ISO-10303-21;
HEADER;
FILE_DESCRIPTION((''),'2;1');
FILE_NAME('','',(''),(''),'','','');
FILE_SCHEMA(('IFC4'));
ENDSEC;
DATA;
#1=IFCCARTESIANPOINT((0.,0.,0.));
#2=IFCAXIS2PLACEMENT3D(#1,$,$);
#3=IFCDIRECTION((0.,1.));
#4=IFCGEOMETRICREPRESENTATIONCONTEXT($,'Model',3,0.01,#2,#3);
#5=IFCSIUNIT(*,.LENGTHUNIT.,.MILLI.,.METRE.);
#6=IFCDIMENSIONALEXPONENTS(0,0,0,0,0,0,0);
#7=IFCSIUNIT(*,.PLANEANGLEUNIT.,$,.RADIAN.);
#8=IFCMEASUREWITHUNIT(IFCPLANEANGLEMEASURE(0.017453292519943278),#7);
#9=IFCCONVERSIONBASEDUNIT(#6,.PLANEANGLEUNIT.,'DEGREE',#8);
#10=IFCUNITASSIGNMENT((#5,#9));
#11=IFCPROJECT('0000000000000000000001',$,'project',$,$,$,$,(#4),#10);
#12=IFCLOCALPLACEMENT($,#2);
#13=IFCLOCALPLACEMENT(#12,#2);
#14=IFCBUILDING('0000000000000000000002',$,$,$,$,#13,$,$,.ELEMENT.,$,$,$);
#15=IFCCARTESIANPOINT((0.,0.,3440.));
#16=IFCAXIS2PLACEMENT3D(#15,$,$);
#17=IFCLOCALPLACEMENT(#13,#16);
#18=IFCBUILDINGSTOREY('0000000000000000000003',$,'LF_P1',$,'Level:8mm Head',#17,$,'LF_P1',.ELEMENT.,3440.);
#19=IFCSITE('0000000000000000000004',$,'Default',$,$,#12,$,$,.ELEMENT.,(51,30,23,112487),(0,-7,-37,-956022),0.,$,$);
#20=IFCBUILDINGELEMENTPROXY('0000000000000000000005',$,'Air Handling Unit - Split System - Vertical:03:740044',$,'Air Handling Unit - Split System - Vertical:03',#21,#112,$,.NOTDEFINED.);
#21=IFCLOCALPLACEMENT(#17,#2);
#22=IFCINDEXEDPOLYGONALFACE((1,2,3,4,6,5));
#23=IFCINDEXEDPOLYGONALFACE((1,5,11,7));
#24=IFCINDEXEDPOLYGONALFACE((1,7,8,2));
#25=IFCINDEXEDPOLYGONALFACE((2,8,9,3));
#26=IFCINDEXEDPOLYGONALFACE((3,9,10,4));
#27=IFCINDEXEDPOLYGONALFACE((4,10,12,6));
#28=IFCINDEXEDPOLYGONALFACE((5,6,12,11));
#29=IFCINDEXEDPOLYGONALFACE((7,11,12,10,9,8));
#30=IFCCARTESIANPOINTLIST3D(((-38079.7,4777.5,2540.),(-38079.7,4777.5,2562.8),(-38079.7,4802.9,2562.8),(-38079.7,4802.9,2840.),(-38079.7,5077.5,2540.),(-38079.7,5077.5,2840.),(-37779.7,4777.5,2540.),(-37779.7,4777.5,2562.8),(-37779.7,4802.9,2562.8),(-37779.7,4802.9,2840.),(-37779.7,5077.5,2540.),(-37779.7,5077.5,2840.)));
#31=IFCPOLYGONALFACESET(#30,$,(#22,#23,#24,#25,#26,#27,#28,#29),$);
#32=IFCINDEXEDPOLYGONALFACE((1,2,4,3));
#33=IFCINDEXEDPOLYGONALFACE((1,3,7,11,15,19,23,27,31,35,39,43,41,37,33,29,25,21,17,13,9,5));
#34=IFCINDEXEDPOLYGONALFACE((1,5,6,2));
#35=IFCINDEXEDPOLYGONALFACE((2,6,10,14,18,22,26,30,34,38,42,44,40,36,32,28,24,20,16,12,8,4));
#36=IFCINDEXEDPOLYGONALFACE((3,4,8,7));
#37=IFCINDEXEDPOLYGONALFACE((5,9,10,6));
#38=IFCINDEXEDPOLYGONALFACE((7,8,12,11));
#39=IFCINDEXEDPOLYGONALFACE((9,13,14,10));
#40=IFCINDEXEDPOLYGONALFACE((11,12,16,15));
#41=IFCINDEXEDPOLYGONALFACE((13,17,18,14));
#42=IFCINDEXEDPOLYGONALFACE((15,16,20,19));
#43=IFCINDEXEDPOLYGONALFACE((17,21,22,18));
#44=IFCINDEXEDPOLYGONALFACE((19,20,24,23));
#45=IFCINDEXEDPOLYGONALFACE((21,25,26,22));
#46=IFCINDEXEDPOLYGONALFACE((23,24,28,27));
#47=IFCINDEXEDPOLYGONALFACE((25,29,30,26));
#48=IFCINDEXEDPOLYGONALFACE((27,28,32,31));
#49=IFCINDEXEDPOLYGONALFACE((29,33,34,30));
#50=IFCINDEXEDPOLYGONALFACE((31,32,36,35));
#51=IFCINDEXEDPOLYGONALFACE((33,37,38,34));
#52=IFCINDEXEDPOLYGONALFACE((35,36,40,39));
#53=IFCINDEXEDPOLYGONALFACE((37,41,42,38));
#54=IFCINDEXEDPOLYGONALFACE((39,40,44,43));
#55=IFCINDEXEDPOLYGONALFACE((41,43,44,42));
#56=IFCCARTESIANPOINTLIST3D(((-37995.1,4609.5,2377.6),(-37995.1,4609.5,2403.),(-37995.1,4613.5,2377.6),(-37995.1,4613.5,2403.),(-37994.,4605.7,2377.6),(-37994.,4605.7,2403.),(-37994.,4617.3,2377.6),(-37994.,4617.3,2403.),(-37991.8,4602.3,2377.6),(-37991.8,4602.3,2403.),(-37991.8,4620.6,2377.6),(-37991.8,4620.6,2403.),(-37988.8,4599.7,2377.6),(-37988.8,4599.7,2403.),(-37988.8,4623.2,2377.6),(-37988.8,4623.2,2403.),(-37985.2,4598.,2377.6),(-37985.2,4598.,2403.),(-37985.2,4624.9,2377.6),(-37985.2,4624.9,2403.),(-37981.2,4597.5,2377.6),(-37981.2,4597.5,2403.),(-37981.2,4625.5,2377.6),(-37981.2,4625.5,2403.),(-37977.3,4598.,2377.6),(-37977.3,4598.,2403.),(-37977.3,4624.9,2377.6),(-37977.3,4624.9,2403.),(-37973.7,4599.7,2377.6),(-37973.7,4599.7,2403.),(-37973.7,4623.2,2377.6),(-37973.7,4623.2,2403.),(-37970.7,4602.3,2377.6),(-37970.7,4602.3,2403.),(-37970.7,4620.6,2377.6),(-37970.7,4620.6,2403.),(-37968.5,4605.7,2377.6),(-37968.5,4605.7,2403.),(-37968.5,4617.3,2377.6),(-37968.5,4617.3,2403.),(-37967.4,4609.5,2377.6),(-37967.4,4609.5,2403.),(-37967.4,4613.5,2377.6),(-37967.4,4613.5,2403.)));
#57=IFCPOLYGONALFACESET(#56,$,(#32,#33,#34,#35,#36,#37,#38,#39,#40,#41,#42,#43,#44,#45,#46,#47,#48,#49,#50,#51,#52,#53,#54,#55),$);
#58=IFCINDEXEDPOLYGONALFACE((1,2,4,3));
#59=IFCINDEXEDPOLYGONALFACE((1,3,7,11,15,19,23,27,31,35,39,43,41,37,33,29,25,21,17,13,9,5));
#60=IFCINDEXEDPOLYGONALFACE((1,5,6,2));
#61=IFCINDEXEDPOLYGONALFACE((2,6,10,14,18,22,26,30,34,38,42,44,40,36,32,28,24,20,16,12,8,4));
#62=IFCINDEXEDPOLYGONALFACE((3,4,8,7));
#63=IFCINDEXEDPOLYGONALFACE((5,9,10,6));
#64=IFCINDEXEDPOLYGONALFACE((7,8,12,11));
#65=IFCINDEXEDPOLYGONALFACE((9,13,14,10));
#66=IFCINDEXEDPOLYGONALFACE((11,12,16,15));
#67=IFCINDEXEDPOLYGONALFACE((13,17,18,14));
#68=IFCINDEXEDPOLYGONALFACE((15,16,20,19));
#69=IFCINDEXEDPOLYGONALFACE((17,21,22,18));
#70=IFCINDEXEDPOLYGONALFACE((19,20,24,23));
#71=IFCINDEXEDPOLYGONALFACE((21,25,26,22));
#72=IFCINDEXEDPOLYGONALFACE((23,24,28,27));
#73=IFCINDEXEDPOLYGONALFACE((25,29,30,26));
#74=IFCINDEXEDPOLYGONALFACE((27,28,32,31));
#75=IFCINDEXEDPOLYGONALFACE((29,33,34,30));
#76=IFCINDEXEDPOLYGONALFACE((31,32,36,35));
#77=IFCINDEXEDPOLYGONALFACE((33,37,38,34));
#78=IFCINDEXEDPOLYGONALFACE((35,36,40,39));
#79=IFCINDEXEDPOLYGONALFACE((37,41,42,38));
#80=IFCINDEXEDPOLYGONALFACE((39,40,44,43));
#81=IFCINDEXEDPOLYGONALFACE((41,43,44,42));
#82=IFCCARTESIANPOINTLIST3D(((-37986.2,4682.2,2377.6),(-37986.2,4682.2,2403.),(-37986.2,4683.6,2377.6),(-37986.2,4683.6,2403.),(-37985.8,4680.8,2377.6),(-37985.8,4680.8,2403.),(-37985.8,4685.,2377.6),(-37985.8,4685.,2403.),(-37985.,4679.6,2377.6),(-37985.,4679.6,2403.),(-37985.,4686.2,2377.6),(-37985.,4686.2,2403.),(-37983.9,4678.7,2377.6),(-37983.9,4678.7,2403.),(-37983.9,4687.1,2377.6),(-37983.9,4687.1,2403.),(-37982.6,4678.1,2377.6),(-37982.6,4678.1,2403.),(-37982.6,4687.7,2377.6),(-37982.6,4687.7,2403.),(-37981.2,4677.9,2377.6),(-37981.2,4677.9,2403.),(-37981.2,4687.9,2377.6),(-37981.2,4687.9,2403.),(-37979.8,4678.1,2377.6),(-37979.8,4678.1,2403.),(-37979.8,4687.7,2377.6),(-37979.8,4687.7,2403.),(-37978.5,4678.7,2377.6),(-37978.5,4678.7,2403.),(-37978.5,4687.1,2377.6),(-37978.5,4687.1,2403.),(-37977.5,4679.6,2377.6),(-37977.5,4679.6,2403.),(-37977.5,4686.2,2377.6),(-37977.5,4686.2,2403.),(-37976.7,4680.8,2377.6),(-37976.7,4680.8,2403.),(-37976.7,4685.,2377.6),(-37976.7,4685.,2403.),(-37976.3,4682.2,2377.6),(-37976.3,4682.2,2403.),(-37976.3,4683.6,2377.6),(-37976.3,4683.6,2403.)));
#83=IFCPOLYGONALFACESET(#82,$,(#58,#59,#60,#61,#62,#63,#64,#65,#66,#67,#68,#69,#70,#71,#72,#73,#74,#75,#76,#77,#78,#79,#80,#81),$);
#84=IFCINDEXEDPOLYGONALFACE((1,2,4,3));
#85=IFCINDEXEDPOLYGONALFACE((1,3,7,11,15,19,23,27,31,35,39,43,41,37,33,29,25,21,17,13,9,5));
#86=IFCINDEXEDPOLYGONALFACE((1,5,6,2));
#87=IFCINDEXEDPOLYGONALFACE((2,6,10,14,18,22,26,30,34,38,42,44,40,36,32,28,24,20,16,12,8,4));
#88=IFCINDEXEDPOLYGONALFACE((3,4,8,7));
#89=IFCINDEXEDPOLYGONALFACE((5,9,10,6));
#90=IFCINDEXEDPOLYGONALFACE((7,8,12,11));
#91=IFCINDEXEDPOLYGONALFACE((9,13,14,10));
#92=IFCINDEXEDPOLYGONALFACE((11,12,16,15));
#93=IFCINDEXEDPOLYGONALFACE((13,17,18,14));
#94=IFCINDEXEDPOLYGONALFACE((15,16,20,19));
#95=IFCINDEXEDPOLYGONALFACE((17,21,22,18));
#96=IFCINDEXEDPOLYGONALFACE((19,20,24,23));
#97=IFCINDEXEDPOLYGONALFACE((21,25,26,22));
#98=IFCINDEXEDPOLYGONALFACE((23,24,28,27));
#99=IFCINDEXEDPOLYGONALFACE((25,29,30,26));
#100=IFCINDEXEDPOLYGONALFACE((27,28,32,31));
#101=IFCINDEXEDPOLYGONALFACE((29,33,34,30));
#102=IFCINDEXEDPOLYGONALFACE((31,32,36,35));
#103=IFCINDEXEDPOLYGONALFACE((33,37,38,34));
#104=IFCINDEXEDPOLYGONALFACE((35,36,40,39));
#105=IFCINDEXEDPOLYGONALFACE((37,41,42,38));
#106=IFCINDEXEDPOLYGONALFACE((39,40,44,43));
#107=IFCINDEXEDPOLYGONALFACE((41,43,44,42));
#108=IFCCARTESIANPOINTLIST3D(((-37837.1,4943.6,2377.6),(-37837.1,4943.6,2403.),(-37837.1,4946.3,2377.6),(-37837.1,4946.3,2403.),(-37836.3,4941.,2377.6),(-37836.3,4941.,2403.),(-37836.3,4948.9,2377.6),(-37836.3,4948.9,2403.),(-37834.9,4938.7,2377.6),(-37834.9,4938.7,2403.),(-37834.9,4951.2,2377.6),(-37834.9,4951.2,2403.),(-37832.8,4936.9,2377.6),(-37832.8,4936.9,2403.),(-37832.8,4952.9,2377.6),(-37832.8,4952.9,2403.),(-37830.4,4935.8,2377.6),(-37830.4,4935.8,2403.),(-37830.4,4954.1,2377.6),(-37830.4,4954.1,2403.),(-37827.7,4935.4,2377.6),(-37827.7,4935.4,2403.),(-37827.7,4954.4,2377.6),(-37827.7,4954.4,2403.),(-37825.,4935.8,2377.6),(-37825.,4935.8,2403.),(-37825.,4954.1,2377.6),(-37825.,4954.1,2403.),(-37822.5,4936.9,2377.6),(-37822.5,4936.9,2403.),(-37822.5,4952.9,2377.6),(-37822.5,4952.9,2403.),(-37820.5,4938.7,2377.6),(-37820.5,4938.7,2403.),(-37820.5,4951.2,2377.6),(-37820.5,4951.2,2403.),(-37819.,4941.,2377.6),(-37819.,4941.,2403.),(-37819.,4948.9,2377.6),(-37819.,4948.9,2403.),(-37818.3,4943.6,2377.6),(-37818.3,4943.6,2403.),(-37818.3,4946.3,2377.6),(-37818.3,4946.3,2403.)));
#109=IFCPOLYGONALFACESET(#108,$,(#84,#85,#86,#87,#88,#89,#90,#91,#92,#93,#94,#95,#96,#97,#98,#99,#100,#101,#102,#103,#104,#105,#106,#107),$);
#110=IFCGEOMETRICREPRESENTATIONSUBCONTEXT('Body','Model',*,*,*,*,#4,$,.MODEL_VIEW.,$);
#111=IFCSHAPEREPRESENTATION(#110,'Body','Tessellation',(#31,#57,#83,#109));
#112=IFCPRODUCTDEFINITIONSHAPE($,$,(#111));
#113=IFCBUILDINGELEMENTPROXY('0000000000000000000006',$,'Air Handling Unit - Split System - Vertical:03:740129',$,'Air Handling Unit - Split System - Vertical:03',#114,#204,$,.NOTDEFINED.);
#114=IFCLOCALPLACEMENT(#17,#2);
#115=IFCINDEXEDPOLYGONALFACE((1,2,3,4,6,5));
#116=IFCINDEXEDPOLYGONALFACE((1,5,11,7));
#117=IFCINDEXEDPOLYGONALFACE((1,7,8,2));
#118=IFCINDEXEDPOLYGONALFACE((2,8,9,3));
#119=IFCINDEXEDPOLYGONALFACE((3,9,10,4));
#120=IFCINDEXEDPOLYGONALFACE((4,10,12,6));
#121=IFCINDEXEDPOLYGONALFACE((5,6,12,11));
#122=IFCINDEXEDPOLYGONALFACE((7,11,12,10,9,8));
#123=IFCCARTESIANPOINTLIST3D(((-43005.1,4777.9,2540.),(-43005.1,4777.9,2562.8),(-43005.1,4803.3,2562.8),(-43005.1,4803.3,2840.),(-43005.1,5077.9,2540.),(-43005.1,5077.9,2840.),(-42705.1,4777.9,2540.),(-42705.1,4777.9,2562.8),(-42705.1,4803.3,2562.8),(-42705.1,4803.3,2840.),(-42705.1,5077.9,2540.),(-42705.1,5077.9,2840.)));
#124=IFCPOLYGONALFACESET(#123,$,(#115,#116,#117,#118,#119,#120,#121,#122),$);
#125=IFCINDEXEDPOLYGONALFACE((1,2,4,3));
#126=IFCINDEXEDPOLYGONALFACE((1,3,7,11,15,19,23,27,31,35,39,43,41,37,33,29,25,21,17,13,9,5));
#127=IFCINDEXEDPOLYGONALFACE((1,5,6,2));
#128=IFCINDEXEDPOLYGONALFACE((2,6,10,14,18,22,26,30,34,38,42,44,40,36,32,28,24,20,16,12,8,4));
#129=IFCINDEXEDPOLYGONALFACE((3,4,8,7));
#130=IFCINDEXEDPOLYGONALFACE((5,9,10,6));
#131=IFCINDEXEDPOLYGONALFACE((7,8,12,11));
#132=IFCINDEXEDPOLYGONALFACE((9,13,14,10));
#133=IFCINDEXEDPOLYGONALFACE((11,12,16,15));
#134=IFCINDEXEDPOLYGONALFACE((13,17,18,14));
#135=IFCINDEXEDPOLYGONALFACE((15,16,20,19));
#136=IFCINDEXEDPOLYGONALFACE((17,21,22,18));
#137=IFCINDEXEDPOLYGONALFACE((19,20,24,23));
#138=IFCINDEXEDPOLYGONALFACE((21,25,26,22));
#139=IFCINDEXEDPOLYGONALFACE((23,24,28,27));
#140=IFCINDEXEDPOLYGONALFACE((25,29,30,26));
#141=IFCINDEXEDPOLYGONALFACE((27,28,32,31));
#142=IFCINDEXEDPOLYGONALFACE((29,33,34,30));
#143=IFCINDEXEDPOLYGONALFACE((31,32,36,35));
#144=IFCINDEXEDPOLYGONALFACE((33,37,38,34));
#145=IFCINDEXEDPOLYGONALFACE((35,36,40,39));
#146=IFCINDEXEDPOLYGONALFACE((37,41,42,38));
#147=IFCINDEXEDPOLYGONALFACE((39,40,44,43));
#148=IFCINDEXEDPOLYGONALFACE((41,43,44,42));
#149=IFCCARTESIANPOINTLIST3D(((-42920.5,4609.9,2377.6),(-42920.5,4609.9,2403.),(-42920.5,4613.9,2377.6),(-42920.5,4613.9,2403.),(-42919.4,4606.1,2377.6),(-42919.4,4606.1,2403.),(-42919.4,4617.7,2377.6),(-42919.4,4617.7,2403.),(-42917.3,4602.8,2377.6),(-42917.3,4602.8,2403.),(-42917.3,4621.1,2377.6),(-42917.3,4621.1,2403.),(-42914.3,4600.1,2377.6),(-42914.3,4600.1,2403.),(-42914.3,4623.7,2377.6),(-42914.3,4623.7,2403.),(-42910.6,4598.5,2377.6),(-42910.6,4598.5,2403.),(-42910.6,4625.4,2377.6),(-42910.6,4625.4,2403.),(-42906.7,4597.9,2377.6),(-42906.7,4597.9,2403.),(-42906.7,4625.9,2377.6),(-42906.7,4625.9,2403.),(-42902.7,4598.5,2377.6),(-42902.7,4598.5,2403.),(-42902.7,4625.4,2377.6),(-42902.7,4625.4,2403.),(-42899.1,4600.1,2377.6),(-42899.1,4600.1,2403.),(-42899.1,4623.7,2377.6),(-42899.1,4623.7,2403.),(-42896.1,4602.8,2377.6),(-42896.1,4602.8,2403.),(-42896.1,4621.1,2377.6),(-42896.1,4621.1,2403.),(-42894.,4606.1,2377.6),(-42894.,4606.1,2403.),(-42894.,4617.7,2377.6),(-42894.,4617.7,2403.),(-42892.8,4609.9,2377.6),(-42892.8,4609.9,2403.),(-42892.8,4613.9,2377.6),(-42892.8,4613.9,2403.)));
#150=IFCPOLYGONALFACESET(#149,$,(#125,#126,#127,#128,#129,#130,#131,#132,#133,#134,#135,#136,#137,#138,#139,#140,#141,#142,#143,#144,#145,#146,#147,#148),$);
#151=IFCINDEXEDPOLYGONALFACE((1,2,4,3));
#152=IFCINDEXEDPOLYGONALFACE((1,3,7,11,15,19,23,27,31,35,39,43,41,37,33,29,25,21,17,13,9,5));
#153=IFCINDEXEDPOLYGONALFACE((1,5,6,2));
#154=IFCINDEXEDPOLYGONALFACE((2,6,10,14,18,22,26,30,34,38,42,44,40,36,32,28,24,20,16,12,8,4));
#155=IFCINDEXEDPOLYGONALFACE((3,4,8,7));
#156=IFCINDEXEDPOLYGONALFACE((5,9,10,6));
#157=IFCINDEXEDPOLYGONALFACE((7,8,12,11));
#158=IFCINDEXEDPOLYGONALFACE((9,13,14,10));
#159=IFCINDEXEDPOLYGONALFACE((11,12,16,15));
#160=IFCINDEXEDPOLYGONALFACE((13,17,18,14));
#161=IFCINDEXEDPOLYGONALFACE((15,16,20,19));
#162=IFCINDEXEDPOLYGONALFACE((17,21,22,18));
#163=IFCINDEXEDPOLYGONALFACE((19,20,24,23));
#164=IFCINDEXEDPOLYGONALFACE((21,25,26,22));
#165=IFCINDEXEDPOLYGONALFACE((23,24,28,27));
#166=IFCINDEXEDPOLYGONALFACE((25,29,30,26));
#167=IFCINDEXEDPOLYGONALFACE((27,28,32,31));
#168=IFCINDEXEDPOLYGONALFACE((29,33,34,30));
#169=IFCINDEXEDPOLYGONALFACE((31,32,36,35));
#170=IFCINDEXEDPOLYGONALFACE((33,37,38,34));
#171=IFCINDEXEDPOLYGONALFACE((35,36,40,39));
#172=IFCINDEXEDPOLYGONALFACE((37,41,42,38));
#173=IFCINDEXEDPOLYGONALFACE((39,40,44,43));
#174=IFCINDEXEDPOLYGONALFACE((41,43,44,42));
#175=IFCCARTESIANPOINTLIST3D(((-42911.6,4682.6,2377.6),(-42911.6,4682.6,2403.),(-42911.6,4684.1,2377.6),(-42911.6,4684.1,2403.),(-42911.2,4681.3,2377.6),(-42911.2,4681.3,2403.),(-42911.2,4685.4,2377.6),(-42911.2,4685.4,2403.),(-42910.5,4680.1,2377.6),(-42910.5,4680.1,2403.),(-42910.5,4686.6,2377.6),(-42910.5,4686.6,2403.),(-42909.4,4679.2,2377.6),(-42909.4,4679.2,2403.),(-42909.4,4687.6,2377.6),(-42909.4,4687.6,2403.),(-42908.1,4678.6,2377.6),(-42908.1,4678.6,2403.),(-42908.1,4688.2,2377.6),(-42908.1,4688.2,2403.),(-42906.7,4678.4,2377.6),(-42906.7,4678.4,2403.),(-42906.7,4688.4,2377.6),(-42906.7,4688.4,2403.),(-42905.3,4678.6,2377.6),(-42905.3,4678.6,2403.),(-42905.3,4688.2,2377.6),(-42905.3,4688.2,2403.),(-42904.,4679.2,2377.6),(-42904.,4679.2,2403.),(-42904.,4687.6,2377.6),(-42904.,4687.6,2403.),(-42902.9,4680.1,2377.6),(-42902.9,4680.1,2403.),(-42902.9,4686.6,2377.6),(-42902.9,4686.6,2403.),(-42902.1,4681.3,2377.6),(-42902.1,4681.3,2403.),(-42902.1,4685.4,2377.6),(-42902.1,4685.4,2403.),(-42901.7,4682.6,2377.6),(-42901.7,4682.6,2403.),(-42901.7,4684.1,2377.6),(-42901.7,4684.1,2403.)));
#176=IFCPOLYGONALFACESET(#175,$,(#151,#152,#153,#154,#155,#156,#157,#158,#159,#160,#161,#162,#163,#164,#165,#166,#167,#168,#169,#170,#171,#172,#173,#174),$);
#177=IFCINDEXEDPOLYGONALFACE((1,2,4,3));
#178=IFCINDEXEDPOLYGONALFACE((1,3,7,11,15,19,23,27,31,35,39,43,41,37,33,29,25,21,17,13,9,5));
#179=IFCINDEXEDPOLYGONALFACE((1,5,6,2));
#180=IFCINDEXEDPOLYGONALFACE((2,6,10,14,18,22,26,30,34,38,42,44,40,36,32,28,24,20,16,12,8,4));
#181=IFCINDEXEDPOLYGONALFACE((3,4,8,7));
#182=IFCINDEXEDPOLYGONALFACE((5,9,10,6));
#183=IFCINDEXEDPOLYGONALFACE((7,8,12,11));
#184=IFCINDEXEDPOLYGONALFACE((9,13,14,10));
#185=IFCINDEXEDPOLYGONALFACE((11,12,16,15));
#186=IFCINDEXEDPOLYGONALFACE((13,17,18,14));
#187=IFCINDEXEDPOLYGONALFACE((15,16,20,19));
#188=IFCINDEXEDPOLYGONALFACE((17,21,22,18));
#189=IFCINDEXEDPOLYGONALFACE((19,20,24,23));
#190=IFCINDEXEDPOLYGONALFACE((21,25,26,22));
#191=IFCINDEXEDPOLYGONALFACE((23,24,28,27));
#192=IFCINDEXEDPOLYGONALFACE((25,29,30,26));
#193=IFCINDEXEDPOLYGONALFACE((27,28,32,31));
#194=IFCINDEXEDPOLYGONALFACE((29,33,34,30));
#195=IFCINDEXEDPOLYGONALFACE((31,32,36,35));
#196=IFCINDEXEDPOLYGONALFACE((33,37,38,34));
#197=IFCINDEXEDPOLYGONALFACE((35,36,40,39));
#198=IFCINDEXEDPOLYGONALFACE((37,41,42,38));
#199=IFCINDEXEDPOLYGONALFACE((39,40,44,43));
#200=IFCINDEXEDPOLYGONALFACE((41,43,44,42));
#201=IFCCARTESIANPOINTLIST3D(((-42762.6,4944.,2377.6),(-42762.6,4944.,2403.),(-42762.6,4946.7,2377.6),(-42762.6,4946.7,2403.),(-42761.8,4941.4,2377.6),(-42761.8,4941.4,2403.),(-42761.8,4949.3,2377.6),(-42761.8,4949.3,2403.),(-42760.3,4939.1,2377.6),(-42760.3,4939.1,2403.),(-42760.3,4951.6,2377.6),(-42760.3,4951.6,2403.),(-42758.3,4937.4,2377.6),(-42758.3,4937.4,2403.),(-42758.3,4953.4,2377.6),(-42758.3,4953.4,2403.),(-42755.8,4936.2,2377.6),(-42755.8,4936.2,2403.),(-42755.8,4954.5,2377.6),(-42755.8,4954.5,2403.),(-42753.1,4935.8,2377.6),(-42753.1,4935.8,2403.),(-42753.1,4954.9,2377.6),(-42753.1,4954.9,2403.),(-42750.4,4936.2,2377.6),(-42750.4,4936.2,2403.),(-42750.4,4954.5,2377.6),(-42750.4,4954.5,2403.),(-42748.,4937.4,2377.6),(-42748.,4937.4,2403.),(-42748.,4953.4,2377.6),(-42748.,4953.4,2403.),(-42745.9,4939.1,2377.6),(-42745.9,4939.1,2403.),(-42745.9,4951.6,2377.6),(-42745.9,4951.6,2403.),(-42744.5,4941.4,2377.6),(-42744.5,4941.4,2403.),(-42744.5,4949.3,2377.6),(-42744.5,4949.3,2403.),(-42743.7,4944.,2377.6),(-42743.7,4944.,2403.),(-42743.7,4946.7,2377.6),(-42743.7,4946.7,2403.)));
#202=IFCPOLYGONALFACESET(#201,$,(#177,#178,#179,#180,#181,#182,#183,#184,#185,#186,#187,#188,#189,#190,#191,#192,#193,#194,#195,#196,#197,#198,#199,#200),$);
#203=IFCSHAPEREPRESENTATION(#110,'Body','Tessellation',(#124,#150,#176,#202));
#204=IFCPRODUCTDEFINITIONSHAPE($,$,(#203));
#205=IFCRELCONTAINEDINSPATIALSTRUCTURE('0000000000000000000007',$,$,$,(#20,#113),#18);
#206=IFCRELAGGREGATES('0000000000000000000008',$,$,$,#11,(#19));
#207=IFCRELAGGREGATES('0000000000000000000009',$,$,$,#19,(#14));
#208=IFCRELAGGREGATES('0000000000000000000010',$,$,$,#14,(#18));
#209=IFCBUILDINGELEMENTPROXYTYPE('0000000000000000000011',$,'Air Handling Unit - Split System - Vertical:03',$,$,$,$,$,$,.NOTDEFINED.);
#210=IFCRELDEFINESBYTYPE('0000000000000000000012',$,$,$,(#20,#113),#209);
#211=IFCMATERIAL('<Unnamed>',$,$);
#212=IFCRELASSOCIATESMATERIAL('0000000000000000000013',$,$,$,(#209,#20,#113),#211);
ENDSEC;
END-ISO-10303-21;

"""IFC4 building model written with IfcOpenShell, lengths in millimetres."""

from ifc_helpers import new_model, entity, si_unit, converted_unit, direction, frame, origin, place, context, subcontext, project, spatial, arc, indexed_curve, outline, extrude, source, transform, mapped, material, type_object, type_shapes, element, save


model = new_model("IFC4")

# Units and contexts
model_context = context("Model", 3, precision=0.01, world=origin(), true_north=direction((0.0, 1.0)))
body_context = subcontext(model_context, "Body", "Model", "MODEL_VIEW")
ifc_project = project(units=[si_unit("LENGTHUNIT", "METRE", prefix="MILLI"), converted_unit("PLANEANGLEUNIT", "DEGREE", entity("IfcPlaneAngleMeasure", 0.017453292519943278), si_unit("PLANEANGLEUNIT", "RADIAN"), dimensions=[0, 0, 0, 0, 0, 0, 0])], contexts=[model_context])

# Site, building, storey
site_placement = place(None, origin())
site = spatial("IfcSite", under=ifc_project, at=site_placement, Name="Default", CompositionType="ELEMENT", RefLatitude=(51, 30, 23, 112487), RefLongitude=(0, -7, -37, -956022), RefElevation=0.0)
building_placement = place(site_placement, origin())
building = spatial("IfcBuilding", under=site, at=building_placement, CompositionType="ELEMENT")
storey_placement = place(building_placement, frame((0.0, 0.0, 3440.0)))
storey = spatial("IfcBuildingStorey", under=building, at=storey_placement, Name="LF_P1", ObjectType="Level:8mm Head", LongName="LF_P1", CompositionType="ELEMENT", Elevation=3440.0)

# Shared definitions
ifc_material = material(Name="<Unnamed>")

# Building element proxies
building_element_proxy_type_1 = type_object("IfcBuildingElementProxyType", Name="Air Handling Unit - Split System - Vertical:03", PredefinedType="NOTDEFINED", material=ifc_material)
shared_shape_1 = source(origin(), body_context, "Body", "SweptSolid", [
    extrude(outline(indexed_curve([(-191.5, -107.6), (108.5, -107.6), (108.5, -84.8), (83.1, -84.8), (83.1, 192.4), (-191.5, 192.4), (-191.5, -107.6)], self_intersect=False)), frame((-150.0, 42.4, 191.5), z_axis=(1.0, 0.0, 0.0), x_axis=(0.0, 0.0, 1.0)), (0.0, 0.0, 1.0), 300.0),
    extrude(outline(indexed_curve([(-14.0, 0.0), (0.0, -14.0), (14.0, 0.0), (0.0, 14.0)], segments=[arc(1, 2, 3), arc(3, 4, 1)], self_intersect=False)), frame((51.6, 287.0, 466.0), z_axis=(0.0, 1.0, 0.0), x_axis=(0.0, 0.0, -1.0)), (0.0, 0.0, 1.0), 25.4),
    extrude(outline(indexed_curve([(-5.0, 0.0), (0.0, -5.0), (5.0, 0.0), (0.0, 5.0)], segments=[arc(1, 2, 3), arc(3, 4, 1)], self_intersect=False)), frame((51.6, 287.0, 394.6), z_axis=(0.0, 1.0, 0.0), x_axis=(0.0, 0.0, -1.0)), (0.0, 0.0, 1.0), 25.4),
    extrude(outline(indexed_curve([(-9.5, 0.0), (0.0, -9.5), (9.5, 0.0), (0.0, 9.5)], segments=[arc(1, 2, 3), arc(3, 4, 1)], self_intersect=False)), frame((-102.0, 287.0, 132.6), z_axis=(0.0, 1.0, 0.0), x_axis=(0.0, 0.0, -1.0)), (0.0, 0.0, 1.0), 25.4),
])
type_shapes(building_element_proxy_type_1, [shared_shape_1])
for number, where, z_axis, x_axis, name in (
    (1, (-37929.7, 5077.5, 2690.0), (0.0, -1.0, 0.0), (-1.0, 0.0, 0.0), "Air Handling Unit - Split System - Vertical:03:740044"),
    (2, (-42855.1, 5077.9, 2690.0), (0.0, -1.0, 0.0), (-1.0, 0.0, 0.0), "Air Handling Unit - Split System - Vertical:03:740129"),
):
    element("IfcBuildingElementProxy", number, at=place(storey_placement, frame(where, z_axis=z_axis, x_axis=x_axis)), inside=storey, type_object=building_element_proxy_type_1, material=ifc_material, Name=name, ObjectType="Air Handling Unit - Split System - Vertical:03", PredefinedType="NOTDEFINED", context=body_context, shape_type="MappedRepresentation", body=[
        mapped(shared_shape_1, transform((0.0, 0.0, 0.0), scale=1.0)),
    ])

save(model, "model.ifc")
